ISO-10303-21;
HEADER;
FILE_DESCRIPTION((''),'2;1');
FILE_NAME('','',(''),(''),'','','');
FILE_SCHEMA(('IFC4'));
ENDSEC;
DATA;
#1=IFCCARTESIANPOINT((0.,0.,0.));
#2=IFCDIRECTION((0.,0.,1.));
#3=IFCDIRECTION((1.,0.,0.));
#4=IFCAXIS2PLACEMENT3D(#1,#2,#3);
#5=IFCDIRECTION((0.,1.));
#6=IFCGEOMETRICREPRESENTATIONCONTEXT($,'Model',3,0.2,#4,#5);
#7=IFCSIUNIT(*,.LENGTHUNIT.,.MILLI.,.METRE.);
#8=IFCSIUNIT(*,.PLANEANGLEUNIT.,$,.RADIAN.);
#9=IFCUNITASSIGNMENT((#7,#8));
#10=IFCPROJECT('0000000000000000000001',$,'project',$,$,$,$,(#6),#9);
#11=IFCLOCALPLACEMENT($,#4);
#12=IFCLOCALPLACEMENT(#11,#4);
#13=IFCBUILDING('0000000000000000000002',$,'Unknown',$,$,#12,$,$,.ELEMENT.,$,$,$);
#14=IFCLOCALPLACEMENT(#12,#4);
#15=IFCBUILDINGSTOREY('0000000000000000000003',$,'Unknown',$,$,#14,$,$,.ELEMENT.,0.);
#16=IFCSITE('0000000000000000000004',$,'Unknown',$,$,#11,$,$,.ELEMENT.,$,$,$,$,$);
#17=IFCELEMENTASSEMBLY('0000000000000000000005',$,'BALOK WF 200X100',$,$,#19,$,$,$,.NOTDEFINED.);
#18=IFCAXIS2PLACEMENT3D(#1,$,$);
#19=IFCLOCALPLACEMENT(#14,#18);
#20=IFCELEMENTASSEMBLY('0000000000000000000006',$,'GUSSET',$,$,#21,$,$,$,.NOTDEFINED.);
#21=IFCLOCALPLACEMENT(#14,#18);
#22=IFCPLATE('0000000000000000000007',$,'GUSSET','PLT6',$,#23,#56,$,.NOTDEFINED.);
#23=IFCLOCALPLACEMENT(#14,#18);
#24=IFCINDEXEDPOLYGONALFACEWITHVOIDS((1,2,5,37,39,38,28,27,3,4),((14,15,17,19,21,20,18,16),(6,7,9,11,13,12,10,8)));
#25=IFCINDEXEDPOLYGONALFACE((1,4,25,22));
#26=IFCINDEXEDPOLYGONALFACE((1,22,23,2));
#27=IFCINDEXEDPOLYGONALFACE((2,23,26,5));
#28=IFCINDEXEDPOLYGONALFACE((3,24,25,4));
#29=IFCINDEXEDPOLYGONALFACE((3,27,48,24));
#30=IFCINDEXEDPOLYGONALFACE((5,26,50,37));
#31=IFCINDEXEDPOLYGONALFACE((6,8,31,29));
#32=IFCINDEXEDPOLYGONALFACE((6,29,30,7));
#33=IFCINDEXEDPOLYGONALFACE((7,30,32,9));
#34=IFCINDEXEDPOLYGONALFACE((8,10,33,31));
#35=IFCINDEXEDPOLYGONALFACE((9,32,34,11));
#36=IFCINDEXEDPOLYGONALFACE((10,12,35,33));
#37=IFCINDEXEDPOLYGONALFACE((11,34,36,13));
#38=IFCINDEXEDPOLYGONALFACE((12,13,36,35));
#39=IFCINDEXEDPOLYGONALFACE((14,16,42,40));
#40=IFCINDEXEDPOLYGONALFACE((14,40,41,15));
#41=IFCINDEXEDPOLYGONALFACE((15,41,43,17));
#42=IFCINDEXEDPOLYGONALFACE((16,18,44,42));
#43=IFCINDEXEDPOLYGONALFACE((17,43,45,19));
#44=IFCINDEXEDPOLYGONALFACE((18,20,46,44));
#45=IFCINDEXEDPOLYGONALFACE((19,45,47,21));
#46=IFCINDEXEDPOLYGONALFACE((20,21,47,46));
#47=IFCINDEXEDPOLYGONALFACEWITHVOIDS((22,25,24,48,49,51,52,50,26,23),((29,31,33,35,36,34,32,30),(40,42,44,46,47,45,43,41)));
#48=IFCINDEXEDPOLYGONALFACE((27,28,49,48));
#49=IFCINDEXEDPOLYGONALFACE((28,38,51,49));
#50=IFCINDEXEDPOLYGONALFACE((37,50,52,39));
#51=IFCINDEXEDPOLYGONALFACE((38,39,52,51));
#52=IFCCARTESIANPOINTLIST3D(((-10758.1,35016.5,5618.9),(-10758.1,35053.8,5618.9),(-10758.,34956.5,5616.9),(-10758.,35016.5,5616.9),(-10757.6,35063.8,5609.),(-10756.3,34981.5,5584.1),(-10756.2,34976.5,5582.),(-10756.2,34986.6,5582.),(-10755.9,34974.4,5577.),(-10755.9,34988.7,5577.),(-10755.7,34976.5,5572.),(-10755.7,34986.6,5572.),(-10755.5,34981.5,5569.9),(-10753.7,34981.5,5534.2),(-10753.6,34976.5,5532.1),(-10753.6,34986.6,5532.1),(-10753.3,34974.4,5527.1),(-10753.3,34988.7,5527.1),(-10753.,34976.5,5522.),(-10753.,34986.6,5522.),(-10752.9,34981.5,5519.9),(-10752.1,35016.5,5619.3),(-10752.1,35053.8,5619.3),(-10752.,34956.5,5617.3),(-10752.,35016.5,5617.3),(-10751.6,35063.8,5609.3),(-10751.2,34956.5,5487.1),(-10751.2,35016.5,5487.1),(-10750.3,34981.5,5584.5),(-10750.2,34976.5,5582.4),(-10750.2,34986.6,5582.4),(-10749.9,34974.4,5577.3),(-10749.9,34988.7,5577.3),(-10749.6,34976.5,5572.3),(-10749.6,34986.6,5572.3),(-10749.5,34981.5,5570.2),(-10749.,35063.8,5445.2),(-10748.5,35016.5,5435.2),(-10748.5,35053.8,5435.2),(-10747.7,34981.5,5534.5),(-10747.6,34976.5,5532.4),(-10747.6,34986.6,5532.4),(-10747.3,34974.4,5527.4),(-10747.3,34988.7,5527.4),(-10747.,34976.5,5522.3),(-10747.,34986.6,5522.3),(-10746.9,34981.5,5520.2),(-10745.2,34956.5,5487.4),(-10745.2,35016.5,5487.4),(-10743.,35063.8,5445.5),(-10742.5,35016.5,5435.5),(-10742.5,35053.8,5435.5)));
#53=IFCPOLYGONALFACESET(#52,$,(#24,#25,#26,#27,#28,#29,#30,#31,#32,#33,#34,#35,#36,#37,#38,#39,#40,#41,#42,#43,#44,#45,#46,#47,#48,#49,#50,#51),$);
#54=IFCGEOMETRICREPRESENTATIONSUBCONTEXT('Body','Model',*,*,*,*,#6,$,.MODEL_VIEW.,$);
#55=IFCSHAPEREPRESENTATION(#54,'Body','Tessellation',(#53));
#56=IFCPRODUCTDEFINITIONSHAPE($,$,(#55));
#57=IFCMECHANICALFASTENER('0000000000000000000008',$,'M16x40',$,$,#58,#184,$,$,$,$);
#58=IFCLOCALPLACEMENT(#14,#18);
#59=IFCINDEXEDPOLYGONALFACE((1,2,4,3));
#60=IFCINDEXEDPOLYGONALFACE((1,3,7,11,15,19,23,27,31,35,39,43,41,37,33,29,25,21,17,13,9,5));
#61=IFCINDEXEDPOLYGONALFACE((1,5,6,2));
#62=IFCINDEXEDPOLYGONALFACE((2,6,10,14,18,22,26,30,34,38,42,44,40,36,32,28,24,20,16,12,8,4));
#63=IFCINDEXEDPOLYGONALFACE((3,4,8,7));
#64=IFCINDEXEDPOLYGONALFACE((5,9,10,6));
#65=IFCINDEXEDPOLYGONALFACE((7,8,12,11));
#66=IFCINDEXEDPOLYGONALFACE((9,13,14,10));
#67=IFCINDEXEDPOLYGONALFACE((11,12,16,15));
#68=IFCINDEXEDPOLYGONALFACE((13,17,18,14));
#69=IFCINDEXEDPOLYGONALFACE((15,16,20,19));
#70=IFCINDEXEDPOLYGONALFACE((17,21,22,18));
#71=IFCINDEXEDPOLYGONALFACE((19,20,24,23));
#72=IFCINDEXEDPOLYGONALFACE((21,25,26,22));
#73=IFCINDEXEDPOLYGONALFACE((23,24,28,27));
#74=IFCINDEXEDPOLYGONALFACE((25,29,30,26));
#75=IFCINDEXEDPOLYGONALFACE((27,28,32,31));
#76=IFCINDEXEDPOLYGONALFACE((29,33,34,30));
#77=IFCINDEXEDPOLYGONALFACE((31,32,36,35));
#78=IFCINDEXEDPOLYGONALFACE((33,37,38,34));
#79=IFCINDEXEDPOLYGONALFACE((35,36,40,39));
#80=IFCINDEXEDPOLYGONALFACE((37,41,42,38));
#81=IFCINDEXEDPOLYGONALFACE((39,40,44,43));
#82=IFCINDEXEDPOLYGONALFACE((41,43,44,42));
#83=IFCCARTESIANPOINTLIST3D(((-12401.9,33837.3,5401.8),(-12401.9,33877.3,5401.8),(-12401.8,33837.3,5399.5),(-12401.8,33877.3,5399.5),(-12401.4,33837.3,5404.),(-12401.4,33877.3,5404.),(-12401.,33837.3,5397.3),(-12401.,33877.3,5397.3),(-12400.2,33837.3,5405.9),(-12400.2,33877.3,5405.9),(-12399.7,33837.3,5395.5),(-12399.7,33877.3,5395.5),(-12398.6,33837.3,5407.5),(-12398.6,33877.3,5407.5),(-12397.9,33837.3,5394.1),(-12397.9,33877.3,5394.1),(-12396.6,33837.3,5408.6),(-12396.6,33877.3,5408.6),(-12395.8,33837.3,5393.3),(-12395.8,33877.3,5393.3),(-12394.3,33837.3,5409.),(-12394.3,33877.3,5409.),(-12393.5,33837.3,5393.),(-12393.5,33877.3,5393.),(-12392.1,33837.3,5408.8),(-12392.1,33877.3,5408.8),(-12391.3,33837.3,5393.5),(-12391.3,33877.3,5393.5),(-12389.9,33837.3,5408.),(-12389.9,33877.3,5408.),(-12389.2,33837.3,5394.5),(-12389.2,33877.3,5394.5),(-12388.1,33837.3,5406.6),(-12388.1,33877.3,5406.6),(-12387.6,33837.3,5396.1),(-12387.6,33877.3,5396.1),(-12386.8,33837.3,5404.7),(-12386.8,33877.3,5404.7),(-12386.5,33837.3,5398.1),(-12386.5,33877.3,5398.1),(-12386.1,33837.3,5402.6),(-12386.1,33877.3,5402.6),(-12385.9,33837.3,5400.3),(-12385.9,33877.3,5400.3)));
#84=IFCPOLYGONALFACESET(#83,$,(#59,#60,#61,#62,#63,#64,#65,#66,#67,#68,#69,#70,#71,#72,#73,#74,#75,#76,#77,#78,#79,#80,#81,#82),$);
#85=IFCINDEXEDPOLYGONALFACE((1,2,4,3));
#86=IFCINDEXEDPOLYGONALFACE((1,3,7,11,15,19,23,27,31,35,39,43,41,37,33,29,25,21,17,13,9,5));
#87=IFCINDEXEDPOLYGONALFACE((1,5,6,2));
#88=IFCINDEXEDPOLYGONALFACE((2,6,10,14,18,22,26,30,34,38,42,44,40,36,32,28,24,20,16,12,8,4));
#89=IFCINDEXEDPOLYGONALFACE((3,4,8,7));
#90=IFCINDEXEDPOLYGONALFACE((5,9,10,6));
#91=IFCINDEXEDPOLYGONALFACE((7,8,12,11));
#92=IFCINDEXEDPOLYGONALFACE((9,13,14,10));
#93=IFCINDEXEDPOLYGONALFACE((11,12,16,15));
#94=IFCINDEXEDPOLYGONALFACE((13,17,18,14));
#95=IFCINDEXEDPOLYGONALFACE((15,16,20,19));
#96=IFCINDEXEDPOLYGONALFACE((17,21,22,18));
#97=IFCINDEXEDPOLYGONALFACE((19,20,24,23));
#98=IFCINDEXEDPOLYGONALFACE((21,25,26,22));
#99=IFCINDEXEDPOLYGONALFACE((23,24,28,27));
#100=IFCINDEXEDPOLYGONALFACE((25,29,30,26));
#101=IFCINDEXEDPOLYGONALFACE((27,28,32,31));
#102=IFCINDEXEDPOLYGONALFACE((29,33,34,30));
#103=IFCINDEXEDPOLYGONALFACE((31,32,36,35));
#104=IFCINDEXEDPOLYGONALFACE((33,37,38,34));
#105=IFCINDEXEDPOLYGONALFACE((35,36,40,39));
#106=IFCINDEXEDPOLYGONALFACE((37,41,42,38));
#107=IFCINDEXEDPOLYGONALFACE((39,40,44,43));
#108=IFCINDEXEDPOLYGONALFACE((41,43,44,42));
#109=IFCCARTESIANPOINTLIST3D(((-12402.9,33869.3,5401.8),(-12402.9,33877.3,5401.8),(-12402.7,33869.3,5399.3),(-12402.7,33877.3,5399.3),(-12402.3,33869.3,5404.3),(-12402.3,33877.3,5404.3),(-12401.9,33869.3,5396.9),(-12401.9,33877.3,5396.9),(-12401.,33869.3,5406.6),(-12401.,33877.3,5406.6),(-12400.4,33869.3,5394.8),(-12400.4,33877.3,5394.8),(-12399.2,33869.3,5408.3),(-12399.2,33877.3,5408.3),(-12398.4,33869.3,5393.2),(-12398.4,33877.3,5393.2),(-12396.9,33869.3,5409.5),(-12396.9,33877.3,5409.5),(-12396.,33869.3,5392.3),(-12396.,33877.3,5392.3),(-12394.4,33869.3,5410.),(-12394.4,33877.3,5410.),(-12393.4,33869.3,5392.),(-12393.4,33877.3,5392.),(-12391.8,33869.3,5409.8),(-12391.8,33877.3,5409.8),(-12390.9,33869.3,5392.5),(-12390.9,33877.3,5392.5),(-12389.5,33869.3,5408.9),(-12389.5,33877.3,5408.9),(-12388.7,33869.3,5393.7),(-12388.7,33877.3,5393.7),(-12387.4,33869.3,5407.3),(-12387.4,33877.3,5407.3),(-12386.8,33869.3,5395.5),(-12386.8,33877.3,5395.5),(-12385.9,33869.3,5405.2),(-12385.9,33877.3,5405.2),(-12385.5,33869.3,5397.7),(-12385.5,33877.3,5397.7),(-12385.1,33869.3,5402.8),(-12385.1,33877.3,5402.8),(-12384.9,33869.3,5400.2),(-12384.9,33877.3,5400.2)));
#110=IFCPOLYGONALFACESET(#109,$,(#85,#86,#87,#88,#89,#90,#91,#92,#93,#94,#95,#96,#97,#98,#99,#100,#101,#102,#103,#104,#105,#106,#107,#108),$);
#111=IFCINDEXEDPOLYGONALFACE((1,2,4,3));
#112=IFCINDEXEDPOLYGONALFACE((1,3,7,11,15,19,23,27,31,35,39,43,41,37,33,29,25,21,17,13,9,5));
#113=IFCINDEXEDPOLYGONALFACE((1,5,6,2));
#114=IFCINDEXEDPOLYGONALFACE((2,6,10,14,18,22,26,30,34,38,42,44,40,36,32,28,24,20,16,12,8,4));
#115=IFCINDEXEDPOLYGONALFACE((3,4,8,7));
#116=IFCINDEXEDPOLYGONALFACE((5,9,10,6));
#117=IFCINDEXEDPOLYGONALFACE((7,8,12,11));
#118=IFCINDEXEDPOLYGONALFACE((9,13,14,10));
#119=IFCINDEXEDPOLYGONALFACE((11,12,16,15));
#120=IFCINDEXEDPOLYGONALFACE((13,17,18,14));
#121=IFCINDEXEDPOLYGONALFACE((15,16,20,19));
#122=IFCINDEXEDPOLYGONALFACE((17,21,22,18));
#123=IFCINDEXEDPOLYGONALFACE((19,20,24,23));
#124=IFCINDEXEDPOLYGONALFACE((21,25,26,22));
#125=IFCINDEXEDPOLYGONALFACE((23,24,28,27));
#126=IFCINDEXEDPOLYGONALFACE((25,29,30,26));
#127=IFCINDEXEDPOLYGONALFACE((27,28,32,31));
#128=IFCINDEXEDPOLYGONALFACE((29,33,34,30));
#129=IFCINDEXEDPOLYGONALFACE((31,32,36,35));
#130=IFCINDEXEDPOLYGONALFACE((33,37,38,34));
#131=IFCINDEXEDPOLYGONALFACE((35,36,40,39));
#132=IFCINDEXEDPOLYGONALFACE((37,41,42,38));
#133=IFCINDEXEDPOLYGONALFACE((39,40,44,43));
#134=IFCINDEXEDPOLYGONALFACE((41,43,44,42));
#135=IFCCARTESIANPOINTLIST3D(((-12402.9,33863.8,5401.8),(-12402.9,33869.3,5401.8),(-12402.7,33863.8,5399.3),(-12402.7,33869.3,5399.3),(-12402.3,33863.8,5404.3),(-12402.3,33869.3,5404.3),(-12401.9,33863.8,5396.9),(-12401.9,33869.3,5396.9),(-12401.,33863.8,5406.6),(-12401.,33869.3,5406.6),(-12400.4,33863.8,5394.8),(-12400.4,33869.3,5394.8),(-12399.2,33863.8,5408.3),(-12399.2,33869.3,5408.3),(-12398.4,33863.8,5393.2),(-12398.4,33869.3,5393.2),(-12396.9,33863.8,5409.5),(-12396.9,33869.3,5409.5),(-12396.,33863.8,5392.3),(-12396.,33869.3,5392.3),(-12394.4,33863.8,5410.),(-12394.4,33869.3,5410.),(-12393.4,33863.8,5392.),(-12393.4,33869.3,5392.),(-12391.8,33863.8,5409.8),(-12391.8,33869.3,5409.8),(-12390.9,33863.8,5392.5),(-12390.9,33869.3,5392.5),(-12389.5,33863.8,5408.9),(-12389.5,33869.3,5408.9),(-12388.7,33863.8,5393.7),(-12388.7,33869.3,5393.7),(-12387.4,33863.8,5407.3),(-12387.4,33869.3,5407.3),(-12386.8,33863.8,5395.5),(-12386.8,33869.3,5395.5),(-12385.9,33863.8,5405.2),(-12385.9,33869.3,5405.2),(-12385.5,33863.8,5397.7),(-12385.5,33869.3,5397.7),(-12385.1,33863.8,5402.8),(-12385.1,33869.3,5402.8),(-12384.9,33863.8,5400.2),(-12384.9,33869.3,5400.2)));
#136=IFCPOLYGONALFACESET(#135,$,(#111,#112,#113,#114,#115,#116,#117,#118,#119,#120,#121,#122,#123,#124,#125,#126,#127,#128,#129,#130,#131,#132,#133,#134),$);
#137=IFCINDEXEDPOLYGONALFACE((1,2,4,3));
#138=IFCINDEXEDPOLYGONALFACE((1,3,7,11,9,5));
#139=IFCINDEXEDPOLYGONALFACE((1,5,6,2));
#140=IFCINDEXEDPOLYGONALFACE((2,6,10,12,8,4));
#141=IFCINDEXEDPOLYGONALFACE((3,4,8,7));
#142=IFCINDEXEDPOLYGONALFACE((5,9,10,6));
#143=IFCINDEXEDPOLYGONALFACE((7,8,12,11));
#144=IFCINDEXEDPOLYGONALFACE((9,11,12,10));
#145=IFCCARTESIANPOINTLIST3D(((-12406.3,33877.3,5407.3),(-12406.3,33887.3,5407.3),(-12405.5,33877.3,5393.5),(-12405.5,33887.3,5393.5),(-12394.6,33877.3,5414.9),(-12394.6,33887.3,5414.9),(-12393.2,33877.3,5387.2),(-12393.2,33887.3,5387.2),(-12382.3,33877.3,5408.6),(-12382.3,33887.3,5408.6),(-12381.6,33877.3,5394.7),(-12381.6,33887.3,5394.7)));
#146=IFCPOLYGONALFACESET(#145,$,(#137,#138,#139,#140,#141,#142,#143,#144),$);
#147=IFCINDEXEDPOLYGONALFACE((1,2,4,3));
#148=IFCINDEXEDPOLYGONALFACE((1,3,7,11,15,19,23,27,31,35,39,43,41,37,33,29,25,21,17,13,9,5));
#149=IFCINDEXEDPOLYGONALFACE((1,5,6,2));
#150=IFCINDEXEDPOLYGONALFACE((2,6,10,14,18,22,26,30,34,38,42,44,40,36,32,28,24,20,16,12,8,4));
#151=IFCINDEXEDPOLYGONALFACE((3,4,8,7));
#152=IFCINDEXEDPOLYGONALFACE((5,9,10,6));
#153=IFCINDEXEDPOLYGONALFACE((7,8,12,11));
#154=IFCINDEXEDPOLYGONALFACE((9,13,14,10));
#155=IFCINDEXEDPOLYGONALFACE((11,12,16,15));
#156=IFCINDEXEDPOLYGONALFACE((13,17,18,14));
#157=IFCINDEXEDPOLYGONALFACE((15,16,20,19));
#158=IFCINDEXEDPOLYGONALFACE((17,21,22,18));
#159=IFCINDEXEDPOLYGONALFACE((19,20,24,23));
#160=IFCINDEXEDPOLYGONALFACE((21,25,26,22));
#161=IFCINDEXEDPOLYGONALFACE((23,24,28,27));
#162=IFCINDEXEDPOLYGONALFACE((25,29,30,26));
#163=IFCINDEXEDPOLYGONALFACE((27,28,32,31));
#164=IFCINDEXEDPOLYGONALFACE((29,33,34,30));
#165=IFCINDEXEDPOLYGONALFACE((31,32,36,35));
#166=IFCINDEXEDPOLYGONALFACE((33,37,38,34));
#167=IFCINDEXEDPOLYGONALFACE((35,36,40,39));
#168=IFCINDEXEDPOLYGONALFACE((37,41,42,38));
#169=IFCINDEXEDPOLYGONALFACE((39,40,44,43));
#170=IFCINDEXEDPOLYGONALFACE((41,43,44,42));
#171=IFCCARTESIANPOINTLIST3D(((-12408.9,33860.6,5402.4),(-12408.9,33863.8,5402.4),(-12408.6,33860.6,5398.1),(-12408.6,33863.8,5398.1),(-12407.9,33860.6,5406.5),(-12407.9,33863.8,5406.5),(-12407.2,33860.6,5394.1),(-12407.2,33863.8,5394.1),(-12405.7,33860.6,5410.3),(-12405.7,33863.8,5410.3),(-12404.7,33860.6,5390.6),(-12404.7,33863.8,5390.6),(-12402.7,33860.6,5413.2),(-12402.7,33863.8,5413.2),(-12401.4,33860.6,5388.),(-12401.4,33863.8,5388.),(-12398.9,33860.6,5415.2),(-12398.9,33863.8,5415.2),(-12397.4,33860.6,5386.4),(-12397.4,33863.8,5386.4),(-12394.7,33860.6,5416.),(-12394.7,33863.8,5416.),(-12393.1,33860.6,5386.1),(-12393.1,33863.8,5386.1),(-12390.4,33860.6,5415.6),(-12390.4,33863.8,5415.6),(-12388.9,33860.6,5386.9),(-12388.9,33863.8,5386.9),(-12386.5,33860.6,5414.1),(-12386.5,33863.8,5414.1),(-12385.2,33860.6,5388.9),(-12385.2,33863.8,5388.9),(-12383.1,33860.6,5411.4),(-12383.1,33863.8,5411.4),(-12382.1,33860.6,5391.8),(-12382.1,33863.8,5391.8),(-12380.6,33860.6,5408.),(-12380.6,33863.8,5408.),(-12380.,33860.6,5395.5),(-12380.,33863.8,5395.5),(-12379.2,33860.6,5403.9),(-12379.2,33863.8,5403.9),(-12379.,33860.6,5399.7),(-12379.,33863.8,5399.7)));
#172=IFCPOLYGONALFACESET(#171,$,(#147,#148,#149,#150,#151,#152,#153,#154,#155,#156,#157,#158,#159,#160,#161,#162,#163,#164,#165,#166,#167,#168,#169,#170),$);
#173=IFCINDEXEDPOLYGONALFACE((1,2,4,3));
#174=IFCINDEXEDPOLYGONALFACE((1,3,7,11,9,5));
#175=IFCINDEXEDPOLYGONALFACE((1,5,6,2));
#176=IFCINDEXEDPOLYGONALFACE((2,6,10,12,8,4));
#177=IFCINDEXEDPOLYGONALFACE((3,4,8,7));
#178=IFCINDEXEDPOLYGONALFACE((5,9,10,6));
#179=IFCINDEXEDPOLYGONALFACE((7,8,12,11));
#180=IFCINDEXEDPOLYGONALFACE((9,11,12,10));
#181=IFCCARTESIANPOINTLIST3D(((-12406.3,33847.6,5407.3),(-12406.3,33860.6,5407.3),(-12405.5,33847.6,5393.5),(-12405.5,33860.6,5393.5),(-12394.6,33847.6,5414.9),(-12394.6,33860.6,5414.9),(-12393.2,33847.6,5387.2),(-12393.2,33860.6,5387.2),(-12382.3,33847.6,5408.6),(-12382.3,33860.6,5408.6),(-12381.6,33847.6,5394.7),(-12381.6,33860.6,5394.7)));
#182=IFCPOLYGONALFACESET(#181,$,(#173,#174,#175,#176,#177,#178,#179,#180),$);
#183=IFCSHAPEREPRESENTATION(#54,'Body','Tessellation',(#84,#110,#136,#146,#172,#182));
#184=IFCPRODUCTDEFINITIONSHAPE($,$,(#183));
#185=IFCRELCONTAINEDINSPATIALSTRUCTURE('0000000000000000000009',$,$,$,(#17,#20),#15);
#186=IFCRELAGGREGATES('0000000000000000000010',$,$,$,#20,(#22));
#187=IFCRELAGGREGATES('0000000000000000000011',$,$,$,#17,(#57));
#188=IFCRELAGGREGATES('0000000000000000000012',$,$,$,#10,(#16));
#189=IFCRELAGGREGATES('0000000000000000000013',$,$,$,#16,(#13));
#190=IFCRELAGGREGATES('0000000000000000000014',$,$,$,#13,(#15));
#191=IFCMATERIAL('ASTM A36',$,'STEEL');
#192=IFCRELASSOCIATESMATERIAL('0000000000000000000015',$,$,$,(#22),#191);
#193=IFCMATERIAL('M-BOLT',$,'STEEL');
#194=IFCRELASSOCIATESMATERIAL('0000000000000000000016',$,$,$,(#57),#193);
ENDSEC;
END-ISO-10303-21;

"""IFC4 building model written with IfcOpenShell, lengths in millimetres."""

from ifc_helpers import new_model, si_unit, direction, frame, origin_with_axes, place, context, subcontext, project, spatial, line, arc, indexed_curve, outline, extrude, source, transform, mapped, material, element, aggregate, save


model = new_model("IFC4")

# Units and contexts
model_context = context("Model", 3, precision=0.2, world=origin_with_axes(), true_north=direction((0.0, 1.0)))
body_context = subcontext(model_context, "Body", "Model", "MODEL_VIEW")
ifc_project = project(units=[si_unit("LENGTHUNIT", "METRE", prefix="MILLI"), si_unit("PLANEANGLEUNIT", "RADIAN")], contexts=[model_context])

# Site, building, storey
site_placement = place(None, origin_with_axes())
site = spatial("IfcSite", under=ifc_project, at=site_placement, Name="Unknown", CompositionType="ELEMENT")
building_placement = place(site_placement, origin_with_axes())
building = spatial("IfcBuilding", under=site, at=building_placement, Name="Unknown", CompositionType="ELEMENT")
storey_placement = place(building_placement, origin_with_axes())
storey = spatial("IfcBuildingStorey", under=building, at=storey_placement, Name="Unknown", CompositionType="ELEMENT", Elevation=0.0)

# Element assembly
assembly_1_placement = place(storey_placement, frame((-7044.1, 33866.5, 5721.5), z_axis=(0.0, 1.0, 0.0), x_axis=(-0.99863, 0.0, -0.052336)))
assembly_1 = element("IfcElementAssembly", 1, at=assembly_1_placement, inside=storey, Name="BALOK WF 200X100", PredefinedType="NOTDEFINED")
ifc_material_1 = material(Name="ASTM A36", Category="STEEL")

# Element assembly, plate, voiding features
assembly_2_placement = place(storey_placement, frame((-10745.5, 35063.8, 5435.4), z_axis=(-0.99863, 0.0, -0.052336), x_axis=(0.0, -1.0, 0.0)))
assembly_2 = element("IfcElementAssembly", 2, at=assembly_2_placement, inside=storey, Name="GUSSET", PredefinedType="NOTDEFINED")
plate_1_placement = place(assembly_2_placement, origin_with_axes())
plate_1 = element("IfcPlate", 3, at=plate_1_placement, material=ifc_material_1, Name="GUSSET", Description="PLT6", PredefinedType="NOTDEFINED", context=body_context, shape_type="SolidModel", body=[
    extrude(outline(indexed_curve([(0.0, 0.0), (47.2, 0.0), (47.2, 52.0), (107.3, 52.0), (107.3, 182.0), (47.2, 182.0), (47.2, 184.0), (0.0, 184.0)], segments=[line(1, 2, 3, 4, 5, 6, 7, 8, 1)])), frame((0.0, 0.0, 3.0), z_axis=(0.0, 0.0, 1.0), x_axis=(1.0, 0.0, 0.0)), (0.0, 0.0, -1.0), 6.0),
])
voiding_feature_1_placement = place(plate_1_placement, frame((0.0, 174.0, 0.0), z_axis=(0.0, 0.0, 1.0), x_axis=(0.707107, 0.707107, 0.0)))
element("IfcVoidingFeature", 4, at=voiding_feature_1_placement, cuts=plate_1, Name="SLAB", PredefinedType="HOLE", context=body_context, shape_type="SolidModel", body=[
    extrude(outline(indexed_curve([(0.0, 0.0), (14.1, 0.0), (7.1, 7.1)], segments=[line(1, 2, 3, 1)])), frame((0.0, 0.0, 3.0), z_axis=(0.0, 0.0, 1.0), x_axis=(1.0, 0.0, 0.0)), (0.0, 0.0, -1.0), 6.0),
])
voiding_feature_2_placement = place(plate_1_placement, origin_with_axes())
element("IfcVoidingFeature", 5, at=voiding_feature_2_placement, cuts=plate_1, Name="SLAB", PredefinedType="HOLE", context=body_context, shape_type="SolidModel", body=[
    extrude(outline(indexed_curve([(0.0, 0.0), (10.0, 0.0), (0.0, 10.0)], segments=[line(1, 2, 3, 1)])), frame((0.0, 0.0, 3.0), z_axis=(0.0, 0.0, 1.0), x_axis=(1.0, 0.0, 0.0)), (0.0, 0.0, -1.0), 6.0),
])
voiding_feature_3_placement = place(plate_1_placement, frame((82.3, 92.0, 3.5), z_axis=(1.0, 0.0, 0.0), x_axis=(0.0, 0.0, -1.0)))
element("IfcVoidingFeature", 6, at=voiding_feature_3_placement, cuts=plate_1, Name="BEAM", PredefinedType="HOLE", context=body_context, shape_type="SolidModel", body=[
    extrude(outline(indexed_curve([(7.1, 0.0), (5.1, 5.1), (0.0, 7.1), (-5.1, 5.1), (-7.1, 0.0), (-5.1, -5.1), (0.0, -7.1), (5.1, -5.1)], segments=[line(1, 2, 3, 4, 5, 6, 7, 8, 1)])), frame((0.0, 0.0, 0.0), z_axis=(-1.0, 0.0, 0.0), x_axis=(0.0, 0.0, 1.0)), (0.0, 0.0, -1.0), 7.0),
])
voiding_feature_4_placement = place(plate_1_placement, frame((82.3, 142.0, 3.5), z_axis=(1.0, 0.0, 0.0), x_axis=(0.0, 0.0, -1.0)))
element("IfcVoidingFeature", 7, at=voiding_feature_4_placement, cuts=plate_1, Name="BEAM", PredefinedType="HOLE", context=body_context, shape_type="SolidModel", body=[
    extrude(outline(indexed_curve([(7.1, 0.0), (5.1, 5.1), (0.0, 7.1), (-5.1, 5.1), (-7.1, 0.0), (-5.1, -5.1), (0.0, -7.1), (5.1, -5.1)], segments=[line(1, 2, 3, 4, 5, 6, 7, 8, 1)])), frame((0.0, 0.0, 0.0), z_axis=(-1.0, 0.0, 0.0), x_axis=(0.0, 0.0, 1.0)), (0.0, 0.0, -1.0), 7.0),
])
aggregate(assembly_2, [plate_1])

# Mechanical fastener
ifc_material_2 = material(Name="M-BOLT", Category="STEEL")
shared_shape_1 = source(origin_with_axes(), body_context, "Body", "SweptSolid", [
    extrude(outline(indexed_curve([(8.0, 0.0), (0.0, 8.0), (-8.0, 0.0), (0.0, -8.0)], segments=[arc(1, 2, 3), arc(3, 4, 1)])), frame((0.0, 0.0, 0.0), z_axis=(0.0, 0.0, -1.0), x_axis=(0.0, 1.0, 0.0)), (0.0, 0.0, 1.0), 40.0),
    extrude(outline(indexed_curve([(9.0, 0.0), (0.0, 9.0), (-9.0, 0.0), (0.0, -9.0)], segments=[arc(1, 2, 3), arc(3, 4, 1)])), frame((0.0, 0.0, 0.0), z_axis=(0.0, 0.0, -1.0), x_axis=(0.0, 1.0, 0.0)), (0.0, 0.0, 1.0), 8.0),
    extrude(outline(indexed_curve([(9.0, 0.0), (0.0, 9.0), (-9.0, 0.0), (0.0, -9.0)], segments=[arc(1, 2, 3), arc(3, 4, 1)])), frame((0.0, 0.0, -8.0), z_axis=(0.0, 0.0, -1.0), x_axis=(0.0, 1.0, 0.0)), (0.0, 0.0, 1.0), 5.5),
    extrude(outline(indexed_curve([(13.9, 0.0), (6.9, 12.0), (-6.9, 12.0), (-13.9, 0.0), (-6.9, -12.0), (6.9, -12.0)], segments=[line(1, 2, 3, 4, 5, 6, 1)])), frame((0.0, 0.0, 10.0), z_axis=(0.0, 0.0, -1.0), x_axis=(0.0, 1.0, 0.0)), (0.0, 0.0, 1.0), 10.0),
    extrude(outline(indexed_curve([(15.0, 0.0), (0.0, 15.0), (-15.0, 0.0), (0.0, -15.0)], segments=[arc(1, 2, 3), arc(3, 4, 1)])), frame((0.0, 0.0, -13.5), z_axis=(0.0, 0.0, -1.0), x_axis=(0.0, 1.0, 0.0)), (0.0, 0.0, 1.0), 3.2),
    extrude(outline(indexed_curve([(13.9, 0.0), (6.9, 12.0), (-6.9, 12.0), (-13.9, 0.0), (-6.9, -12.0), (6.9, -12.0)], segments=[line(1, 2, 3, 4, 5, 6, 1)])), frame((0.0, 0.0, -16.7), z_axis=(0.0, 0.0, -1.0), x_axis=(0.0, 1.0, 0.0)), (0.0, 0.0, 1.0), 13.0),
])
mechanical_fastener_1_placement = place(assembly_1_placement, frame((5359.2, -40.0, 10.7), z_axis=(-0.000004, 0.0, 1.0), x_axis=(-1.0, 0.0, -0.000004)))
mechanical_fastener_1 = element("IfcMechanicalFastener", 8, at=mechanical_fastener_1_placement, material=ifc_material_2, Name="M16x40", context=body_context, shape_type="MappedRepresentation", body=[
    mapped(shared_shape_1, transform((0.0, 0.0, 0.0))),
])
aggregate(assembly_1, [mechanical_fastener_1])

save(model, "model.ifc")
